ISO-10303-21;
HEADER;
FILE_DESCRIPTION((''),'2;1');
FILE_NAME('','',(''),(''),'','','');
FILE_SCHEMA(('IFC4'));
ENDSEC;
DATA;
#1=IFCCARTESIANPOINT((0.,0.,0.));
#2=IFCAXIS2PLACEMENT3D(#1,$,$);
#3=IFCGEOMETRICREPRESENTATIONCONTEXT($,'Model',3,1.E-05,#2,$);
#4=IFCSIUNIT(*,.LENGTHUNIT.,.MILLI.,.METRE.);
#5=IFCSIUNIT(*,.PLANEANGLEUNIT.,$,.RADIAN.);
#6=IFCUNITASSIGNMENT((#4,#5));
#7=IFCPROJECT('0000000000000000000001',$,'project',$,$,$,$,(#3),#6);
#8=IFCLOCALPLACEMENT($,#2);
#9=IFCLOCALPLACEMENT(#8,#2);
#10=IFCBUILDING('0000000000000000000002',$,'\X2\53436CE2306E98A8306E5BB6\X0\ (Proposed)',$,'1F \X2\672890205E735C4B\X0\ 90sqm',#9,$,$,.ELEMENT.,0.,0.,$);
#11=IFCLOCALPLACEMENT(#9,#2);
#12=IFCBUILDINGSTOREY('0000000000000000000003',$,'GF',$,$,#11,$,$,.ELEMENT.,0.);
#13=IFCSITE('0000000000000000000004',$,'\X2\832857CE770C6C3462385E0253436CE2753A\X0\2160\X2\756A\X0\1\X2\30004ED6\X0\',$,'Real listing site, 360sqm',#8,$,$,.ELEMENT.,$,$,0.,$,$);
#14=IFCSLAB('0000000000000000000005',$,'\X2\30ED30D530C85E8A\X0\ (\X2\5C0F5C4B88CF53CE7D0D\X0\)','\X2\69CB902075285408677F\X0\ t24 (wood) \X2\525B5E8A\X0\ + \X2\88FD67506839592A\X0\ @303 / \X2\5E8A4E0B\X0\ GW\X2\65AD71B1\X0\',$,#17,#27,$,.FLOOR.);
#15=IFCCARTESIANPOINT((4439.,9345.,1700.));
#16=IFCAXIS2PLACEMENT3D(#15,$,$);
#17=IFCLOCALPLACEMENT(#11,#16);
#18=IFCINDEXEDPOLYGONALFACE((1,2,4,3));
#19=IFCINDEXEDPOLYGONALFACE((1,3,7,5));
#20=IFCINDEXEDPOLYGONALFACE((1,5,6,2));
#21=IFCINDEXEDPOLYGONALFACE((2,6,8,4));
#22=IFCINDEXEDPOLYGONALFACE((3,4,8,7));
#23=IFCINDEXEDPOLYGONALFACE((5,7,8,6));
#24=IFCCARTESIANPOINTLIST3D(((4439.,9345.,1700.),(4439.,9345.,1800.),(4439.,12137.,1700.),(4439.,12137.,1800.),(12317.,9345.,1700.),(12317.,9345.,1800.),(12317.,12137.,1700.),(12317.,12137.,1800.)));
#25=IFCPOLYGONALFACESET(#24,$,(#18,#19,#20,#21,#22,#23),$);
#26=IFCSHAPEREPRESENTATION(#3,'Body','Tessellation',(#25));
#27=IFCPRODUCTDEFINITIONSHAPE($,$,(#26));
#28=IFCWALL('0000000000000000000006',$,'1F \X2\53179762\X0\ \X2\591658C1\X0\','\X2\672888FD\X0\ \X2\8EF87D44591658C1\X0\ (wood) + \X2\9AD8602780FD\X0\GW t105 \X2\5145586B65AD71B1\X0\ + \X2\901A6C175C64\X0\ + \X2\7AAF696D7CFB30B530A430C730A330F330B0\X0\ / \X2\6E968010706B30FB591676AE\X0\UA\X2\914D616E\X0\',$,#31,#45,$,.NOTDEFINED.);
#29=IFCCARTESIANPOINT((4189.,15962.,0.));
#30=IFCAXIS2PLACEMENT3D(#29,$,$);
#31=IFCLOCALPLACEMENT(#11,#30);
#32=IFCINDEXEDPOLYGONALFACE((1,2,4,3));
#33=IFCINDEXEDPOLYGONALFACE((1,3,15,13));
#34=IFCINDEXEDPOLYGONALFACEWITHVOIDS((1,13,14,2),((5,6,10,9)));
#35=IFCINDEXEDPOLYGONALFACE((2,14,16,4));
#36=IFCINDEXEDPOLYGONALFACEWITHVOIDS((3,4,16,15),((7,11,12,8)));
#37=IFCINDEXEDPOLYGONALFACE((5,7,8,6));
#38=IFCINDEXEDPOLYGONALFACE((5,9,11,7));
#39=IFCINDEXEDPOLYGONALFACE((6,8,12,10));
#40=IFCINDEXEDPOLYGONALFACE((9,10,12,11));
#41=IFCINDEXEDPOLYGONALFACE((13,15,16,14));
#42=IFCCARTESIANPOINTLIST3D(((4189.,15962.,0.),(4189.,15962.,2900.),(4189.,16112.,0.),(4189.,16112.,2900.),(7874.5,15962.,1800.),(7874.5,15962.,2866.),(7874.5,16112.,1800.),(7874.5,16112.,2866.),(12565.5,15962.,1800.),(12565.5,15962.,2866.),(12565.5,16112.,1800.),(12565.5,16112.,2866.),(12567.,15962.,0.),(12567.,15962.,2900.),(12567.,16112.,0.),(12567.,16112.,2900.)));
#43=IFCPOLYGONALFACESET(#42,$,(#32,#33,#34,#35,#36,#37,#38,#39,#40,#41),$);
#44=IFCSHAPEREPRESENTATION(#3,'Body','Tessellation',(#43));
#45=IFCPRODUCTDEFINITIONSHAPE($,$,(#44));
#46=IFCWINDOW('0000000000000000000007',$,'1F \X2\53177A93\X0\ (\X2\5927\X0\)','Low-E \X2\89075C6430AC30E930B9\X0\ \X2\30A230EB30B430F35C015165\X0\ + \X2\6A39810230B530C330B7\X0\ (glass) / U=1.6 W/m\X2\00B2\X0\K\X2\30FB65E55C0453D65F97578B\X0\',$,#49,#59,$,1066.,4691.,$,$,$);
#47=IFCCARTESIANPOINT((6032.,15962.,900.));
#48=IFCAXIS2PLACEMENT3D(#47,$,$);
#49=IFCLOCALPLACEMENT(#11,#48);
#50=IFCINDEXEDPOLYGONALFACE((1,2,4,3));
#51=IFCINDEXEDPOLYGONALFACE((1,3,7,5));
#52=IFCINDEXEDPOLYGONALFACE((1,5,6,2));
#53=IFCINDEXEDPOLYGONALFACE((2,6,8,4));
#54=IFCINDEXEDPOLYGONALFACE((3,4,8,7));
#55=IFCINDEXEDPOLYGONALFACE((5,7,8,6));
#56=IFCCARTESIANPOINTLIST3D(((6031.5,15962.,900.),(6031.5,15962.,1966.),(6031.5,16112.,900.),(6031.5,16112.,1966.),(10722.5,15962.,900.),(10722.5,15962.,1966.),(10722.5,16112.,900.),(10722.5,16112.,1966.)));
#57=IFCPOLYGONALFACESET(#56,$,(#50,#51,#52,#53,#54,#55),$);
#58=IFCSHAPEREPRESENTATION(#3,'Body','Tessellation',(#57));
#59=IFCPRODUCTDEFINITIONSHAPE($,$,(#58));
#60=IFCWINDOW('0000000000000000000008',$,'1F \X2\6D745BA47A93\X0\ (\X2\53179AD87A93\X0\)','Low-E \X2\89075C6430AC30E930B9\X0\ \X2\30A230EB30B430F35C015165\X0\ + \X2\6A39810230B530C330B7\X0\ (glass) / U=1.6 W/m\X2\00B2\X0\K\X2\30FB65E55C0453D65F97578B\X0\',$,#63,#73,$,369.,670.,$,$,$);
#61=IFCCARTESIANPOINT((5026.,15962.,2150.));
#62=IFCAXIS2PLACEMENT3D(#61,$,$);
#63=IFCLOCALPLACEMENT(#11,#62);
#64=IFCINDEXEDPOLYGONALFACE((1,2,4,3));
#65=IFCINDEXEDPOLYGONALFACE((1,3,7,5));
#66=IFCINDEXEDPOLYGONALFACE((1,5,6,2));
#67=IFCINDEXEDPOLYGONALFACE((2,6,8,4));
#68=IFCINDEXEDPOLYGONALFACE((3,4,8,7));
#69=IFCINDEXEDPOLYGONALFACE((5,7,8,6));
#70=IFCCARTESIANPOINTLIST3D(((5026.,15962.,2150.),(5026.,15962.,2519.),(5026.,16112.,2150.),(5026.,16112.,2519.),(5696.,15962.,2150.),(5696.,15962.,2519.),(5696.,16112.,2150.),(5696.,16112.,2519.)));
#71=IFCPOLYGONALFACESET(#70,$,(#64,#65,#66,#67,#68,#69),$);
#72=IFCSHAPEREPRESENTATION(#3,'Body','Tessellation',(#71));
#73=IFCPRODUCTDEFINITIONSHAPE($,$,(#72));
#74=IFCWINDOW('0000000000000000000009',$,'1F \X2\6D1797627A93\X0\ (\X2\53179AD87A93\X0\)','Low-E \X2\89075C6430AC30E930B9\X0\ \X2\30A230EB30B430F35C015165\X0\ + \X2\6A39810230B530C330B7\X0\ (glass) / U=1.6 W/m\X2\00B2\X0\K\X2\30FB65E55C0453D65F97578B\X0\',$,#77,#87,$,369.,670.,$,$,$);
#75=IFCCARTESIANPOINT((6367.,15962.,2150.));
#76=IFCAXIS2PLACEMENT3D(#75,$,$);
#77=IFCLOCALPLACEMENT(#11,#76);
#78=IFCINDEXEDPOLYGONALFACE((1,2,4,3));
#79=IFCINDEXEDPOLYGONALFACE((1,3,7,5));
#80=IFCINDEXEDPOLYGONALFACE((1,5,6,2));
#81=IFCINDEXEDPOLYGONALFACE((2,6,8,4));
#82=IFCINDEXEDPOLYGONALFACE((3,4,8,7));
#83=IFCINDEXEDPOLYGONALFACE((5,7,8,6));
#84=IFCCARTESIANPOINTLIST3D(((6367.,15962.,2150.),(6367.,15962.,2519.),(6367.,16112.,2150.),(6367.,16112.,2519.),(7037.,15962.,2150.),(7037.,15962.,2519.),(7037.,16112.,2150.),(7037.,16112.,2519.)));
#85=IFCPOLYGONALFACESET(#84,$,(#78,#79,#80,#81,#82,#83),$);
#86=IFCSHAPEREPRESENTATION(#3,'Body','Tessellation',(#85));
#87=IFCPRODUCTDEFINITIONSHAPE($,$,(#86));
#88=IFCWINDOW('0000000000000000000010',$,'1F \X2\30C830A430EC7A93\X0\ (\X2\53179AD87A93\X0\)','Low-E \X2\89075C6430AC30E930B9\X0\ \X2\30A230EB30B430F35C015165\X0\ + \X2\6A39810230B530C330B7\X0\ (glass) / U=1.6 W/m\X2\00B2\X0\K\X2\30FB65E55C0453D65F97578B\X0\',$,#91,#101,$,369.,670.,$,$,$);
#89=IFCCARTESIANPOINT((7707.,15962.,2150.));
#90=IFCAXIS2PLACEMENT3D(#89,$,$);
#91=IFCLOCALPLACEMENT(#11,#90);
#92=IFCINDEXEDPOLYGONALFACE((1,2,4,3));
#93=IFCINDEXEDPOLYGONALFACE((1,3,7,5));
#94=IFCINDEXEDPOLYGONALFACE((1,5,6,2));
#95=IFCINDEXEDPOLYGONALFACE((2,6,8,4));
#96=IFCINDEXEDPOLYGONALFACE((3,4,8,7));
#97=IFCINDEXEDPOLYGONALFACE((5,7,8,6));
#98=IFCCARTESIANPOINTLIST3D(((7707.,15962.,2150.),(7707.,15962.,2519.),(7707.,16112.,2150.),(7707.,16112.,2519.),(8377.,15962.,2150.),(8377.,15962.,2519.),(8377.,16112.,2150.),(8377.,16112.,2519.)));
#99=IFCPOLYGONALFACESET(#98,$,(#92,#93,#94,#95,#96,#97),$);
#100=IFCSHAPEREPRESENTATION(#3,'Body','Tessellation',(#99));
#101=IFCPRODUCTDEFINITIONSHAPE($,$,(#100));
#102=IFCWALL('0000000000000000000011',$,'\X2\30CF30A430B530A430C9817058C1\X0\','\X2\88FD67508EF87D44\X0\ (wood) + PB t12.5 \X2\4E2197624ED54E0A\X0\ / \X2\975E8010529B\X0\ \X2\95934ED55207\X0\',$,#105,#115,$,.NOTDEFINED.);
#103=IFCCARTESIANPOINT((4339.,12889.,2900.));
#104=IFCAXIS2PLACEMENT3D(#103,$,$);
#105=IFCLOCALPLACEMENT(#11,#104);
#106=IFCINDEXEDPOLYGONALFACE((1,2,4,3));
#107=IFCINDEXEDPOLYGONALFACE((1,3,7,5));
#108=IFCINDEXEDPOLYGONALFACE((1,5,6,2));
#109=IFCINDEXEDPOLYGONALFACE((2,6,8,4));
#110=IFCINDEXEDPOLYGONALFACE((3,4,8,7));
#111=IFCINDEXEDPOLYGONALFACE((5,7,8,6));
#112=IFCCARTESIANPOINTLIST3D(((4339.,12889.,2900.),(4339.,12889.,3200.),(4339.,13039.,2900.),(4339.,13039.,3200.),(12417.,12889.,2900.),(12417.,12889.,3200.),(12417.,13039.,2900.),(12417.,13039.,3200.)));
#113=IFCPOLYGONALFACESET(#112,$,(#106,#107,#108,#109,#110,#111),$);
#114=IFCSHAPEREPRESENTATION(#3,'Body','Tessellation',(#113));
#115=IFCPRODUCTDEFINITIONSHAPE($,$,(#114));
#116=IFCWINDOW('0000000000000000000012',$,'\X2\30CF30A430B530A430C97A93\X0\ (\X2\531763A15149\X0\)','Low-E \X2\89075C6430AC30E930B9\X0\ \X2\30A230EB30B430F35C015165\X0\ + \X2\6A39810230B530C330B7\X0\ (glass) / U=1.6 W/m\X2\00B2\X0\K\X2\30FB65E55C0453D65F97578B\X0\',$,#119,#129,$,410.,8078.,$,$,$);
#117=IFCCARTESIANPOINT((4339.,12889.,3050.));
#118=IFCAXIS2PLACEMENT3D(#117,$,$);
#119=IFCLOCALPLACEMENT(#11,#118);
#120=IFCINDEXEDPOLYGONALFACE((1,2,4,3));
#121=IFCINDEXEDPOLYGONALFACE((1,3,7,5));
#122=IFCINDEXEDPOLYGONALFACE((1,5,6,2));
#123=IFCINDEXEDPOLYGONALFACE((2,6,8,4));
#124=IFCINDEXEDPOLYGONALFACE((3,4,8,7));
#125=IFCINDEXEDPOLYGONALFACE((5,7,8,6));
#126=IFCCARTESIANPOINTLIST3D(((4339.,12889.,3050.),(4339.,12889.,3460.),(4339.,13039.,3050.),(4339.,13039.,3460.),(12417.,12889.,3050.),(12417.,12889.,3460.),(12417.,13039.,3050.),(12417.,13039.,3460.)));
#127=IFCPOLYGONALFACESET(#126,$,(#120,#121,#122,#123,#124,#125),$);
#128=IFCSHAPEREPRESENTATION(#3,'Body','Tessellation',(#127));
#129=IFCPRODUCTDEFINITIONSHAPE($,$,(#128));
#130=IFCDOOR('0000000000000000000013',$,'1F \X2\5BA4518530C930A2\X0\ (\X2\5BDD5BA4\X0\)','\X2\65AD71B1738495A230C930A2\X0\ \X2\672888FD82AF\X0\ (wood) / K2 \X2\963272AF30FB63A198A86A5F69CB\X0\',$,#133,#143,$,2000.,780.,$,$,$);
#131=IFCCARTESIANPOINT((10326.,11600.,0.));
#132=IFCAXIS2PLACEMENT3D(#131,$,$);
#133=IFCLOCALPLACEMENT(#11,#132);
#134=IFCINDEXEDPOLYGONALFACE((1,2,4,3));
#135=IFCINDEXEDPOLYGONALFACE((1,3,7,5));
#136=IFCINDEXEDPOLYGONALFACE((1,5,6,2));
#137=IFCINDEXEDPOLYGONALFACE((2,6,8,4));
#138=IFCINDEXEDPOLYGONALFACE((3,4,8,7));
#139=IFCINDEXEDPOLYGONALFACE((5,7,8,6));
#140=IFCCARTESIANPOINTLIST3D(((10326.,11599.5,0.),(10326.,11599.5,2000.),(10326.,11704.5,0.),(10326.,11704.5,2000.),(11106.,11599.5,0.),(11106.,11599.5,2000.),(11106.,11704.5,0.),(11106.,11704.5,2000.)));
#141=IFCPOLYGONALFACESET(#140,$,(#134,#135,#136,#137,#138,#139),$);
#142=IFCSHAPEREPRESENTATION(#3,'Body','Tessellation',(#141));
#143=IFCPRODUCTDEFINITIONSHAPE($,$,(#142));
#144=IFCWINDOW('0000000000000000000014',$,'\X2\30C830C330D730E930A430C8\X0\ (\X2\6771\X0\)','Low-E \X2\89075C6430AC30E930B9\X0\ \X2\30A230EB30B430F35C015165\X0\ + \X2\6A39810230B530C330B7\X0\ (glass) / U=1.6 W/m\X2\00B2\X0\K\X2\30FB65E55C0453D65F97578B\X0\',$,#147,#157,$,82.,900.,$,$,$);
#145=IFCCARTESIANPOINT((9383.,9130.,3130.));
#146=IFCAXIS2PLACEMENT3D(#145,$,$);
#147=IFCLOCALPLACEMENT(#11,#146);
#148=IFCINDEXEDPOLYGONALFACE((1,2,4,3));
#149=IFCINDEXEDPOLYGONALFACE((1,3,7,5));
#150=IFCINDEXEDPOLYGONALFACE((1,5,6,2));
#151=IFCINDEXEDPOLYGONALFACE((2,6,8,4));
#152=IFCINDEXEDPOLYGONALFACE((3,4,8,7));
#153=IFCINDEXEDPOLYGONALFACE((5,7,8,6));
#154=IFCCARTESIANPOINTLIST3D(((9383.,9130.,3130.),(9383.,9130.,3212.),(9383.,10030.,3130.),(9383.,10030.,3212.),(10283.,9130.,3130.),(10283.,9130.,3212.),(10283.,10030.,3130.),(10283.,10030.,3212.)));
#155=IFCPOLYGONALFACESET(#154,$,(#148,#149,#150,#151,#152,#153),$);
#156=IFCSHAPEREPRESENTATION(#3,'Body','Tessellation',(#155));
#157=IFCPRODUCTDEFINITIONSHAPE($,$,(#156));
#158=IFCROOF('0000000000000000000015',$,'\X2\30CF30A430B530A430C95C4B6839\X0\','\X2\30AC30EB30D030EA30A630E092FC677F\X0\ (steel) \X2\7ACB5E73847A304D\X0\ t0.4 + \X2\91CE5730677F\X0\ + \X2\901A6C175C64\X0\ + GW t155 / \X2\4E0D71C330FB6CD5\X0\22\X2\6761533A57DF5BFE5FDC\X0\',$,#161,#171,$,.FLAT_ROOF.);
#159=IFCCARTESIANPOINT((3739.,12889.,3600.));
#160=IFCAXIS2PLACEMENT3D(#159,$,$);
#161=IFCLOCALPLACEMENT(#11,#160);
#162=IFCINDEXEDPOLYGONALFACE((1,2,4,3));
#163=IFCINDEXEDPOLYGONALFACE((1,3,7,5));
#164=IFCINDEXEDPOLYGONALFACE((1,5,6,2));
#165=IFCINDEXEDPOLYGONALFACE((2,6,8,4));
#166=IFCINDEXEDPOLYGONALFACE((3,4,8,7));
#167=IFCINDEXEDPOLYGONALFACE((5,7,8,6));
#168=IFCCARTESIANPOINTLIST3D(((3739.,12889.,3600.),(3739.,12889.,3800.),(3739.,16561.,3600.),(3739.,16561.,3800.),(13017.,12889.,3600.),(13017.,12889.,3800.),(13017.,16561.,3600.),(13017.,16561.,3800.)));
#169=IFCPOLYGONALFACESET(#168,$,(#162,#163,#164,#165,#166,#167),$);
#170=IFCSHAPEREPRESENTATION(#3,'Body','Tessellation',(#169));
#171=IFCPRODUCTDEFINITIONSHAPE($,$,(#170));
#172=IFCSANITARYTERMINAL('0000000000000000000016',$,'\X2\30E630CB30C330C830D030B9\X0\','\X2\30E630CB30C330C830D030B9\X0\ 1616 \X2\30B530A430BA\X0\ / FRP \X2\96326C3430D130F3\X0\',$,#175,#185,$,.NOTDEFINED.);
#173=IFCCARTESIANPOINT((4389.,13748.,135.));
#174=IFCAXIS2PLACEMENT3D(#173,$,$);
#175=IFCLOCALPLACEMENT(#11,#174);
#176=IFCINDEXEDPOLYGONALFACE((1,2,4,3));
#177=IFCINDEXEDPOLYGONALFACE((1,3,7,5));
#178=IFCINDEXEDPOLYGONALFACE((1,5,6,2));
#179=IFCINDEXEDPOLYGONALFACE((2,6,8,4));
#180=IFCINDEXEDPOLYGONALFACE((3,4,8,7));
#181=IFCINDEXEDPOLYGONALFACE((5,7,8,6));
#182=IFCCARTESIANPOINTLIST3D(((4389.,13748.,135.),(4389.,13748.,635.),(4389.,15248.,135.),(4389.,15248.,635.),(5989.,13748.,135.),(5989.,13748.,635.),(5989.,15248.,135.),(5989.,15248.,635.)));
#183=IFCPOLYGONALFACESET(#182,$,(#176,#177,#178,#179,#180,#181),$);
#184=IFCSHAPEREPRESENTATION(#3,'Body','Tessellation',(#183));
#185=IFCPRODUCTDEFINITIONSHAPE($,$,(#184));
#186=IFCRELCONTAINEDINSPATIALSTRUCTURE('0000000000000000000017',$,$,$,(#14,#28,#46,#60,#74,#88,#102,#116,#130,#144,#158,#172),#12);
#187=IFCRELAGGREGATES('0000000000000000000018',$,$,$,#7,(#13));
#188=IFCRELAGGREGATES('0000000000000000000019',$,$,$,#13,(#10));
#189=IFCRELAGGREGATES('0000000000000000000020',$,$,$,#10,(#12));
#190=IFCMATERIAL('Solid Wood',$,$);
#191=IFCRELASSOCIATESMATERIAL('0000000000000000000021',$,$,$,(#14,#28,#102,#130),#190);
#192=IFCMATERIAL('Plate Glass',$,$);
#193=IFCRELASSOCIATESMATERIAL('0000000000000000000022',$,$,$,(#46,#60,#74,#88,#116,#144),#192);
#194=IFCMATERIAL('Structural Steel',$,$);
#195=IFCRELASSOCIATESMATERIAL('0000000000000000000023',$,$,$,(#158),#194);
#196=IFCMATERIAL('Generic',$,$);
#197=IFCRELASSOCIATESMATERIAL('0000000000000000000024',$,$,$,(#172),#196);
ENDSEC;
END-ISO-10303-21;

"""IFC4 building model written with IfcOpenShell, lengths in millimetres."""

from ifc_helpers import new_model, si_unit, frame, frame_2d, origin, place, context, project, spatial, rectangle, extrude, material, element, fill, save


model = new_model("IFC4")

# Units and contexts
model_context = context("Model", 3, precision=1e-05, world=origin())
ifc_project = project(units=[si_unit("LENGTHUNIT", "METRE", prefix="MILLI"), si_unit("PLANEANGLEUNIT", "RADIAN")], contexts=[model_context])

# Site, building, storey
site_placement = place(None, origin())
site = spatial("IfcSite", under=ifc_project, at=site_placement, Name="茨城県水戸市千波町2160番1　他", ObjectType="Real listing site, 360sqm", CompositionType="ELEMENT", RefElevation=0.0)
building_placement = place(site_placement, origin())
building = spatial("IfcBuilding", under=site, at=building_placement, Name="千波の風の家 (Proposed)", ObjectType="1F 木造平屋 90sqm", CompositionType="ELEMENT", ElevationOfRefHeight=0.0, ElevationOfTerrain=0.0)
storey_placement = place(building_placement, origin())
storey = spatial("IfcBuildingStorey", under=building, at=storey_placement, Name="GF", CompositionType="ELEMENT", Elevation=0.0)

# Slab
ifc_material_1 = material(Name="Solid Wood")
slab_placement = place(storey_placement, frame((4439.0, 9345.0, 1700.0)))
element("IfcSlab", 1, at=slab_placement, inside=storey, material=ifc_material_1, Name="ロフト床 (小屋裏収納)", Description="構造用合板 t24 (wood) 剛床 + 製材根太 @303 / 床下 GW断熱", PredefinedType="FLOOR", context=model_context, shape_type="SweptSolid", body=[
    extrude(rectangle(XDim=7878.0, YDim=2792.0, at=frame_2d((3939.0, 1396.0))), frame((4439.0, 9345.0, 1700.0)), (0.0, 0.0, 1.0), 100.0),
])

# Wall, openings, windows
wall_1_placement = place(storey_placement, frame((4189.0, 15962.0, 0.0)))
wall_1 = element("IfcWall", 2, at=wall_1_placement, inside=storey, material=ifc_material_1, Name="1F 北面 外壁", Description="木製 軸組外壁 (wood) + 高性能GW t105 充填断熱 + 通気層 + 窯業系サイディング / 準耐火・外皮UA配慮", PredefinedType="NOTDEFINED", context=model_context, shape_type="SweptSolid", body=[
    extrude(rectangle(XDim=8378.0, YDim=150.0, at=frame_2d((4189.0, 75.0))), frame((4189.0, 15962.0, 0.0)), (0.0, 0.0, 1.0), 2900.0),
])
opening_1_placement = place(storey_placement, frame((6032.0, 15962.0, 900.0)))
opening_1 = element("IfcOpeningElement", 3, at=opening_1_placement, cuts=wall_1, PredefinedType="NOTDEFINED", context=model_context, shape_type="SweptSolid", body=[
    extrude(rectangle(XDim=4691.0, YDim=150.0, at=frame_2d((2345.0, 75.0))), frame((6032.0, 15962.0, 900.0)), (0.0, 0.0, 1.0), 1066.0),
])
opening_2_placement = place(storey_placement, frame((5026.0, 15962.0, 2150.0)))
opening_2 = element("IfcOpeningElement", 4, at=opening_2_placement, cuts=wall_1, PredefinedType="NOTDEFINED", context=model_context, shape_type="SweptSolid", body=[
    extrude(rectangle(XDim=670.0, YDim=150.0, at=frame_2d((335.0, 75.0))), frame((5026.0, 15962.0, 2150.0)), (0.0, 0.0, 1.0), 369.0),
])
opening_3_placement = place(storey_placement, frame((6367.0, 15962.0, 2150.0)))
opening_3 = element("IfcOpeningElement", 5, at=opening_3_placement, cuts=wall_1, PredefinedType="NOTDEFINED", context=model_context, shape_type="SweptSolid", body=[
    extrude(rectangle(XDim=670.0, YDim=150.0, at=frame_2d((335.0, 75.0))), frame((6367.0, 15962.0, 2150.0)), (0.0, 0.0, 1.0), 369.0),
])
opening_4_placement = place(storey_placement, frame((7707.0, 15962.0, 2150.0)))
opening_4 = element("IfcOpeningElement", 6, at=opening_4_placement, cuts=wall_1, PredefinedType="NOTDEFINED", context=model_context, shape_type="SweptSolid", body=[
    extrude(rectangle(XDim=670.0, YDim=150.0, at=frame_2d((335.0, 75.0))), frame((7707.0, 15962.0, 2150.0)), (0.0, 0.0, 1.0), 369.0),
])
ifc_material_2 = material(Name="Plate Glass")
window_1_placement = place(storey_placement, frame((6032.0, 15962.0, 900.0)))
window_1 = element("IfcWindow", 7, at=window_1_placement, inside=storey, material=ifc_material_2, Name="1F 北窓 (大)", Description="Low-E 複層ガラス アルゴン封入 + 樹脂サッシ (glass) / U=1.6 W/m²K・日射取得型", OverallHeight=1066.0, OverallWidth=4691.0, context=model_context, shape_type="SweptSolid", body=[
    extrude(rectangle(XDim=4691.0, YDim=150.0, at=frame_2d((2345.0, 75.0))), frame((6032.0, 15962.0, 900.0)), (0.0, 0.0, 1.0), 1066.0),
])
fill(opening_1, window_1)
window_2_placement = place(storey_placement, frame((5026.0, 15962.0, 2150.0)))
window_2 = element("IfcWindow", 8, at=window_2_placement, inside=storey, material=ifc_material_2, Name="1F 浴室窓 (北高窓)", Description="Low-E 複層ガラス アルゴン封入 + 樹脂サッシ (glass) / U=1.6 W/m²K・日射取得型", OverallHeight=369.0, OverallWidth=670.0, context=model_context, shape_type="SweptSolid", body=[
    extrude(rectangle(XDim=670.0, YDim=150.0, at=frame_2d((335.0, 75.0))), frame((5026.0, 15962.0, 2150.0)), (0.0, 0.0, 1.0), 369.0),
])
fill(opening_2, window_2)
window_3_placement = place(storey_placement, frame((6367.0, 15962.0, 2150.0)))
window_3 = element("IfcWindow", 9, at=window_3_placement, inside=storey, material=ifc_material_2, Name="1F 洗面窓 (北高窓)", Description="Low-E 複層ガラス アルゴン封入 + 樹脂サッシ (glass) / U=1.6 W/m²K・日射取得型", OverallHeight=369.0, OverallWidth=670.0, context=model_context, shape_type="SweptSolid", body=[
    extrude(rectangle(XDim=670.0, YDim=150.0, at=frame_2d((335.0, 75.0))), frame((6367.0, 15962.0, 2150.0)), (0.0, 0.0, 1.0), 369.0),
])
fill(opening_3, window_3)
window_4_placement = place(storey_placement, frame((7707.0, 15962.0, 2150.0)))
window_4 = element("IfcWindow", 10, at=window_4_placement, inside=storey, material=ifc_material_2, Name="1F トイレ窓 (北高窓)", Description="Low-E 複層ガラス アルゴン封入 + 樹脂サッシ (glass) / U=1.6 W/m²K・日射取得型", OverallHeight=369.0, OverallWidth=670.0, context=model_context, shape_type="SweptSolid", body=[
    extrude(rectangle(XDim=670.0, YDim=150.0, at=frame_2d((335.0, 75.0))), frame((7707.0, 15962.0, 2150.0)), (0.0, 0.0, 1.0), 369.0),
])
fill(opening_4, window_4)

# Wall, opening, window
wall_2_placement = place(storey_placement, frame((4339.0, 12889.0, 2900.0)))
wall_2 = element("IfcWall", 11, at=wall_2_placement, inside=storey, material=ifc_material_1, Name="ハイサイド腰壁", Description="製材軸組 (wood) + PB t12.5 両面仕上 / 非耐力 間仕切", PredefinedType="NOTDEFINED", context=model_context, shape_type="SweptSolid", body=[
    extrude(rectangle(XDim=8078.0, YDim=150.0, at=frame_2d((4039.0, 75.0))), frame((4339.0, 12889.0, 2900.0)), (0.0, 0.0, 1.0), 700.0),
])
opening_5_placement = place(storey_placement, frame((4339.0, 12889.0, 3050.0)))
opening_5 = element("IfcOpeningElement", 12, at=opening_5_placement, cuts=wall_2, PredefinedType="NOTDEFINED", context=model_context, shape_type="SweptSolid", body=[
    extrude(rectangle(XDim=8078.0, YDim=150.0, at=frame_2d((4039.0, 75.0))), frame((4339.0, 12889.0, 3050.0)), (0.0, 0.0, 1.0), 410.0),
])
window_5_placement = place(storey_placement, frame((4339.0, 12889.0, 3050.0)))
window_5 = element("IfcWindow", 13, at=window_5_placement, inside=storey, material=ifc_material_2, Name="ハイサイド窓 (北採光)", Description="Low-E 複層ガラス アルゴン封入 + 樹脂サッシ (glass) / U=1.6 W/m²K・日射取得型", OverallHeight=410.0, OverallWidth=8078.0, context=model_context, shape_type="SweptSolid", body=[
    extrude(rectangle(XDim=8078.0, YDim=150.0, at=frame_2d((4039.0, 75.0))), frame((4339.0, 12889.0, 3050.0)), (0.0, 0.0, 1.0), 410.0),
])
fill(opening_5, window_5)

# Door
door_1_placement = place(storey_placement, frame((10326.0, 11600.0, 0.0)))
element("IfcDoor", 14, at=door_1_placement, inside=storey, material=ifc_material_1, Name="1F 室内ドア (寝室)", Description="断熱玄関ドア 木製芯 (wood) / K2 防犯・採風機構", OverallHeight=2000.0, OverallWidth=780.0, context=model_context, shape_type="SweptSolid", body=[
    extrude(rectangle(XDim=780.0, YDim=105.0, at=frame_2d((390.0, 52.0))), frame((10326.0, 11600.0, 0.0)), (0.0, 0.0, 1.0), 2000.0),
])

# Window
window_6_placement = place(storey_placement, frame((9383.0, 9130.0, 3130.0)))
element("IfcWindow", 15, at=window_6_placement, inside=storey, material=ifc_material_2, Name="トップライト (東)", Description="Low-E 複層ガラス アルゴン封入 + 樹脂サッシ (glass) / U=1.6 W/m²K・日射取得型", OverallHeight=82.0, OverallWidth=900.0, context=model_context, shape_type="SweptSolid", body=[
    extrude(rectangle(XDim=900.0, YDim=900.0, at=frame_2d((450.0, 450.0))), frame((9383.0, 9130.0, 3130.0)), (0.0, 0.0, 1.0), 82.0),
])

# Roof
ifc_material_3 = material(Name="Structural Steel")
roof_placement = place(storey_placement, frame((3739.0, 12889.0, 3600.0)))
element("IfcRoof", 16, at=roof_placement, inside=storey, material=ifc_material_3, Name="ハイサイド屋根", Description="ガルバリウム鋼板 (steel) 立平葺き t0.4 + 野地板 + 通気層 + GW t155 / 不燃・法22条区域対応", PredefinedType="FLAT_ROOF", context=model_context, shape_type="SweptSolid", body=[
    extrude(rectangle(XDim=9278.0, YDim=3672.0, at=frame_2d((4639.0, 1836.0))), frame((3739.0, 12889.0, 3600.0)), (0.0, 0.0, 1.0), 200.0),
])

# Sanitary terminal
ifc_material_4 = material(Name="Generic")
sanitary_terminal_1_placement = place(storey_placement, frame((4389.0, 13748.0, 135.0)))
element("IfcSanitaryTerminal", 17, at=sanitary_terminal_1_placement, inside=storey, material=ifc_material_4, Name="ユニットバス", Description="ユニットバス 1616 サイズ / FRP 防水パン", PredefinedType="NOTDEFINED", context=model_context, shape_type="SweptSolid", body=[
    extrude(rectangle(XDim=1600.0, YDim=1500.0, at=frame_2d((800.0, 750.0))), frame((4389.0, 13748.0, 135.0)), (0.0, 0.0, 1.0), 500.0),
])

save(model, "model.ifc")
